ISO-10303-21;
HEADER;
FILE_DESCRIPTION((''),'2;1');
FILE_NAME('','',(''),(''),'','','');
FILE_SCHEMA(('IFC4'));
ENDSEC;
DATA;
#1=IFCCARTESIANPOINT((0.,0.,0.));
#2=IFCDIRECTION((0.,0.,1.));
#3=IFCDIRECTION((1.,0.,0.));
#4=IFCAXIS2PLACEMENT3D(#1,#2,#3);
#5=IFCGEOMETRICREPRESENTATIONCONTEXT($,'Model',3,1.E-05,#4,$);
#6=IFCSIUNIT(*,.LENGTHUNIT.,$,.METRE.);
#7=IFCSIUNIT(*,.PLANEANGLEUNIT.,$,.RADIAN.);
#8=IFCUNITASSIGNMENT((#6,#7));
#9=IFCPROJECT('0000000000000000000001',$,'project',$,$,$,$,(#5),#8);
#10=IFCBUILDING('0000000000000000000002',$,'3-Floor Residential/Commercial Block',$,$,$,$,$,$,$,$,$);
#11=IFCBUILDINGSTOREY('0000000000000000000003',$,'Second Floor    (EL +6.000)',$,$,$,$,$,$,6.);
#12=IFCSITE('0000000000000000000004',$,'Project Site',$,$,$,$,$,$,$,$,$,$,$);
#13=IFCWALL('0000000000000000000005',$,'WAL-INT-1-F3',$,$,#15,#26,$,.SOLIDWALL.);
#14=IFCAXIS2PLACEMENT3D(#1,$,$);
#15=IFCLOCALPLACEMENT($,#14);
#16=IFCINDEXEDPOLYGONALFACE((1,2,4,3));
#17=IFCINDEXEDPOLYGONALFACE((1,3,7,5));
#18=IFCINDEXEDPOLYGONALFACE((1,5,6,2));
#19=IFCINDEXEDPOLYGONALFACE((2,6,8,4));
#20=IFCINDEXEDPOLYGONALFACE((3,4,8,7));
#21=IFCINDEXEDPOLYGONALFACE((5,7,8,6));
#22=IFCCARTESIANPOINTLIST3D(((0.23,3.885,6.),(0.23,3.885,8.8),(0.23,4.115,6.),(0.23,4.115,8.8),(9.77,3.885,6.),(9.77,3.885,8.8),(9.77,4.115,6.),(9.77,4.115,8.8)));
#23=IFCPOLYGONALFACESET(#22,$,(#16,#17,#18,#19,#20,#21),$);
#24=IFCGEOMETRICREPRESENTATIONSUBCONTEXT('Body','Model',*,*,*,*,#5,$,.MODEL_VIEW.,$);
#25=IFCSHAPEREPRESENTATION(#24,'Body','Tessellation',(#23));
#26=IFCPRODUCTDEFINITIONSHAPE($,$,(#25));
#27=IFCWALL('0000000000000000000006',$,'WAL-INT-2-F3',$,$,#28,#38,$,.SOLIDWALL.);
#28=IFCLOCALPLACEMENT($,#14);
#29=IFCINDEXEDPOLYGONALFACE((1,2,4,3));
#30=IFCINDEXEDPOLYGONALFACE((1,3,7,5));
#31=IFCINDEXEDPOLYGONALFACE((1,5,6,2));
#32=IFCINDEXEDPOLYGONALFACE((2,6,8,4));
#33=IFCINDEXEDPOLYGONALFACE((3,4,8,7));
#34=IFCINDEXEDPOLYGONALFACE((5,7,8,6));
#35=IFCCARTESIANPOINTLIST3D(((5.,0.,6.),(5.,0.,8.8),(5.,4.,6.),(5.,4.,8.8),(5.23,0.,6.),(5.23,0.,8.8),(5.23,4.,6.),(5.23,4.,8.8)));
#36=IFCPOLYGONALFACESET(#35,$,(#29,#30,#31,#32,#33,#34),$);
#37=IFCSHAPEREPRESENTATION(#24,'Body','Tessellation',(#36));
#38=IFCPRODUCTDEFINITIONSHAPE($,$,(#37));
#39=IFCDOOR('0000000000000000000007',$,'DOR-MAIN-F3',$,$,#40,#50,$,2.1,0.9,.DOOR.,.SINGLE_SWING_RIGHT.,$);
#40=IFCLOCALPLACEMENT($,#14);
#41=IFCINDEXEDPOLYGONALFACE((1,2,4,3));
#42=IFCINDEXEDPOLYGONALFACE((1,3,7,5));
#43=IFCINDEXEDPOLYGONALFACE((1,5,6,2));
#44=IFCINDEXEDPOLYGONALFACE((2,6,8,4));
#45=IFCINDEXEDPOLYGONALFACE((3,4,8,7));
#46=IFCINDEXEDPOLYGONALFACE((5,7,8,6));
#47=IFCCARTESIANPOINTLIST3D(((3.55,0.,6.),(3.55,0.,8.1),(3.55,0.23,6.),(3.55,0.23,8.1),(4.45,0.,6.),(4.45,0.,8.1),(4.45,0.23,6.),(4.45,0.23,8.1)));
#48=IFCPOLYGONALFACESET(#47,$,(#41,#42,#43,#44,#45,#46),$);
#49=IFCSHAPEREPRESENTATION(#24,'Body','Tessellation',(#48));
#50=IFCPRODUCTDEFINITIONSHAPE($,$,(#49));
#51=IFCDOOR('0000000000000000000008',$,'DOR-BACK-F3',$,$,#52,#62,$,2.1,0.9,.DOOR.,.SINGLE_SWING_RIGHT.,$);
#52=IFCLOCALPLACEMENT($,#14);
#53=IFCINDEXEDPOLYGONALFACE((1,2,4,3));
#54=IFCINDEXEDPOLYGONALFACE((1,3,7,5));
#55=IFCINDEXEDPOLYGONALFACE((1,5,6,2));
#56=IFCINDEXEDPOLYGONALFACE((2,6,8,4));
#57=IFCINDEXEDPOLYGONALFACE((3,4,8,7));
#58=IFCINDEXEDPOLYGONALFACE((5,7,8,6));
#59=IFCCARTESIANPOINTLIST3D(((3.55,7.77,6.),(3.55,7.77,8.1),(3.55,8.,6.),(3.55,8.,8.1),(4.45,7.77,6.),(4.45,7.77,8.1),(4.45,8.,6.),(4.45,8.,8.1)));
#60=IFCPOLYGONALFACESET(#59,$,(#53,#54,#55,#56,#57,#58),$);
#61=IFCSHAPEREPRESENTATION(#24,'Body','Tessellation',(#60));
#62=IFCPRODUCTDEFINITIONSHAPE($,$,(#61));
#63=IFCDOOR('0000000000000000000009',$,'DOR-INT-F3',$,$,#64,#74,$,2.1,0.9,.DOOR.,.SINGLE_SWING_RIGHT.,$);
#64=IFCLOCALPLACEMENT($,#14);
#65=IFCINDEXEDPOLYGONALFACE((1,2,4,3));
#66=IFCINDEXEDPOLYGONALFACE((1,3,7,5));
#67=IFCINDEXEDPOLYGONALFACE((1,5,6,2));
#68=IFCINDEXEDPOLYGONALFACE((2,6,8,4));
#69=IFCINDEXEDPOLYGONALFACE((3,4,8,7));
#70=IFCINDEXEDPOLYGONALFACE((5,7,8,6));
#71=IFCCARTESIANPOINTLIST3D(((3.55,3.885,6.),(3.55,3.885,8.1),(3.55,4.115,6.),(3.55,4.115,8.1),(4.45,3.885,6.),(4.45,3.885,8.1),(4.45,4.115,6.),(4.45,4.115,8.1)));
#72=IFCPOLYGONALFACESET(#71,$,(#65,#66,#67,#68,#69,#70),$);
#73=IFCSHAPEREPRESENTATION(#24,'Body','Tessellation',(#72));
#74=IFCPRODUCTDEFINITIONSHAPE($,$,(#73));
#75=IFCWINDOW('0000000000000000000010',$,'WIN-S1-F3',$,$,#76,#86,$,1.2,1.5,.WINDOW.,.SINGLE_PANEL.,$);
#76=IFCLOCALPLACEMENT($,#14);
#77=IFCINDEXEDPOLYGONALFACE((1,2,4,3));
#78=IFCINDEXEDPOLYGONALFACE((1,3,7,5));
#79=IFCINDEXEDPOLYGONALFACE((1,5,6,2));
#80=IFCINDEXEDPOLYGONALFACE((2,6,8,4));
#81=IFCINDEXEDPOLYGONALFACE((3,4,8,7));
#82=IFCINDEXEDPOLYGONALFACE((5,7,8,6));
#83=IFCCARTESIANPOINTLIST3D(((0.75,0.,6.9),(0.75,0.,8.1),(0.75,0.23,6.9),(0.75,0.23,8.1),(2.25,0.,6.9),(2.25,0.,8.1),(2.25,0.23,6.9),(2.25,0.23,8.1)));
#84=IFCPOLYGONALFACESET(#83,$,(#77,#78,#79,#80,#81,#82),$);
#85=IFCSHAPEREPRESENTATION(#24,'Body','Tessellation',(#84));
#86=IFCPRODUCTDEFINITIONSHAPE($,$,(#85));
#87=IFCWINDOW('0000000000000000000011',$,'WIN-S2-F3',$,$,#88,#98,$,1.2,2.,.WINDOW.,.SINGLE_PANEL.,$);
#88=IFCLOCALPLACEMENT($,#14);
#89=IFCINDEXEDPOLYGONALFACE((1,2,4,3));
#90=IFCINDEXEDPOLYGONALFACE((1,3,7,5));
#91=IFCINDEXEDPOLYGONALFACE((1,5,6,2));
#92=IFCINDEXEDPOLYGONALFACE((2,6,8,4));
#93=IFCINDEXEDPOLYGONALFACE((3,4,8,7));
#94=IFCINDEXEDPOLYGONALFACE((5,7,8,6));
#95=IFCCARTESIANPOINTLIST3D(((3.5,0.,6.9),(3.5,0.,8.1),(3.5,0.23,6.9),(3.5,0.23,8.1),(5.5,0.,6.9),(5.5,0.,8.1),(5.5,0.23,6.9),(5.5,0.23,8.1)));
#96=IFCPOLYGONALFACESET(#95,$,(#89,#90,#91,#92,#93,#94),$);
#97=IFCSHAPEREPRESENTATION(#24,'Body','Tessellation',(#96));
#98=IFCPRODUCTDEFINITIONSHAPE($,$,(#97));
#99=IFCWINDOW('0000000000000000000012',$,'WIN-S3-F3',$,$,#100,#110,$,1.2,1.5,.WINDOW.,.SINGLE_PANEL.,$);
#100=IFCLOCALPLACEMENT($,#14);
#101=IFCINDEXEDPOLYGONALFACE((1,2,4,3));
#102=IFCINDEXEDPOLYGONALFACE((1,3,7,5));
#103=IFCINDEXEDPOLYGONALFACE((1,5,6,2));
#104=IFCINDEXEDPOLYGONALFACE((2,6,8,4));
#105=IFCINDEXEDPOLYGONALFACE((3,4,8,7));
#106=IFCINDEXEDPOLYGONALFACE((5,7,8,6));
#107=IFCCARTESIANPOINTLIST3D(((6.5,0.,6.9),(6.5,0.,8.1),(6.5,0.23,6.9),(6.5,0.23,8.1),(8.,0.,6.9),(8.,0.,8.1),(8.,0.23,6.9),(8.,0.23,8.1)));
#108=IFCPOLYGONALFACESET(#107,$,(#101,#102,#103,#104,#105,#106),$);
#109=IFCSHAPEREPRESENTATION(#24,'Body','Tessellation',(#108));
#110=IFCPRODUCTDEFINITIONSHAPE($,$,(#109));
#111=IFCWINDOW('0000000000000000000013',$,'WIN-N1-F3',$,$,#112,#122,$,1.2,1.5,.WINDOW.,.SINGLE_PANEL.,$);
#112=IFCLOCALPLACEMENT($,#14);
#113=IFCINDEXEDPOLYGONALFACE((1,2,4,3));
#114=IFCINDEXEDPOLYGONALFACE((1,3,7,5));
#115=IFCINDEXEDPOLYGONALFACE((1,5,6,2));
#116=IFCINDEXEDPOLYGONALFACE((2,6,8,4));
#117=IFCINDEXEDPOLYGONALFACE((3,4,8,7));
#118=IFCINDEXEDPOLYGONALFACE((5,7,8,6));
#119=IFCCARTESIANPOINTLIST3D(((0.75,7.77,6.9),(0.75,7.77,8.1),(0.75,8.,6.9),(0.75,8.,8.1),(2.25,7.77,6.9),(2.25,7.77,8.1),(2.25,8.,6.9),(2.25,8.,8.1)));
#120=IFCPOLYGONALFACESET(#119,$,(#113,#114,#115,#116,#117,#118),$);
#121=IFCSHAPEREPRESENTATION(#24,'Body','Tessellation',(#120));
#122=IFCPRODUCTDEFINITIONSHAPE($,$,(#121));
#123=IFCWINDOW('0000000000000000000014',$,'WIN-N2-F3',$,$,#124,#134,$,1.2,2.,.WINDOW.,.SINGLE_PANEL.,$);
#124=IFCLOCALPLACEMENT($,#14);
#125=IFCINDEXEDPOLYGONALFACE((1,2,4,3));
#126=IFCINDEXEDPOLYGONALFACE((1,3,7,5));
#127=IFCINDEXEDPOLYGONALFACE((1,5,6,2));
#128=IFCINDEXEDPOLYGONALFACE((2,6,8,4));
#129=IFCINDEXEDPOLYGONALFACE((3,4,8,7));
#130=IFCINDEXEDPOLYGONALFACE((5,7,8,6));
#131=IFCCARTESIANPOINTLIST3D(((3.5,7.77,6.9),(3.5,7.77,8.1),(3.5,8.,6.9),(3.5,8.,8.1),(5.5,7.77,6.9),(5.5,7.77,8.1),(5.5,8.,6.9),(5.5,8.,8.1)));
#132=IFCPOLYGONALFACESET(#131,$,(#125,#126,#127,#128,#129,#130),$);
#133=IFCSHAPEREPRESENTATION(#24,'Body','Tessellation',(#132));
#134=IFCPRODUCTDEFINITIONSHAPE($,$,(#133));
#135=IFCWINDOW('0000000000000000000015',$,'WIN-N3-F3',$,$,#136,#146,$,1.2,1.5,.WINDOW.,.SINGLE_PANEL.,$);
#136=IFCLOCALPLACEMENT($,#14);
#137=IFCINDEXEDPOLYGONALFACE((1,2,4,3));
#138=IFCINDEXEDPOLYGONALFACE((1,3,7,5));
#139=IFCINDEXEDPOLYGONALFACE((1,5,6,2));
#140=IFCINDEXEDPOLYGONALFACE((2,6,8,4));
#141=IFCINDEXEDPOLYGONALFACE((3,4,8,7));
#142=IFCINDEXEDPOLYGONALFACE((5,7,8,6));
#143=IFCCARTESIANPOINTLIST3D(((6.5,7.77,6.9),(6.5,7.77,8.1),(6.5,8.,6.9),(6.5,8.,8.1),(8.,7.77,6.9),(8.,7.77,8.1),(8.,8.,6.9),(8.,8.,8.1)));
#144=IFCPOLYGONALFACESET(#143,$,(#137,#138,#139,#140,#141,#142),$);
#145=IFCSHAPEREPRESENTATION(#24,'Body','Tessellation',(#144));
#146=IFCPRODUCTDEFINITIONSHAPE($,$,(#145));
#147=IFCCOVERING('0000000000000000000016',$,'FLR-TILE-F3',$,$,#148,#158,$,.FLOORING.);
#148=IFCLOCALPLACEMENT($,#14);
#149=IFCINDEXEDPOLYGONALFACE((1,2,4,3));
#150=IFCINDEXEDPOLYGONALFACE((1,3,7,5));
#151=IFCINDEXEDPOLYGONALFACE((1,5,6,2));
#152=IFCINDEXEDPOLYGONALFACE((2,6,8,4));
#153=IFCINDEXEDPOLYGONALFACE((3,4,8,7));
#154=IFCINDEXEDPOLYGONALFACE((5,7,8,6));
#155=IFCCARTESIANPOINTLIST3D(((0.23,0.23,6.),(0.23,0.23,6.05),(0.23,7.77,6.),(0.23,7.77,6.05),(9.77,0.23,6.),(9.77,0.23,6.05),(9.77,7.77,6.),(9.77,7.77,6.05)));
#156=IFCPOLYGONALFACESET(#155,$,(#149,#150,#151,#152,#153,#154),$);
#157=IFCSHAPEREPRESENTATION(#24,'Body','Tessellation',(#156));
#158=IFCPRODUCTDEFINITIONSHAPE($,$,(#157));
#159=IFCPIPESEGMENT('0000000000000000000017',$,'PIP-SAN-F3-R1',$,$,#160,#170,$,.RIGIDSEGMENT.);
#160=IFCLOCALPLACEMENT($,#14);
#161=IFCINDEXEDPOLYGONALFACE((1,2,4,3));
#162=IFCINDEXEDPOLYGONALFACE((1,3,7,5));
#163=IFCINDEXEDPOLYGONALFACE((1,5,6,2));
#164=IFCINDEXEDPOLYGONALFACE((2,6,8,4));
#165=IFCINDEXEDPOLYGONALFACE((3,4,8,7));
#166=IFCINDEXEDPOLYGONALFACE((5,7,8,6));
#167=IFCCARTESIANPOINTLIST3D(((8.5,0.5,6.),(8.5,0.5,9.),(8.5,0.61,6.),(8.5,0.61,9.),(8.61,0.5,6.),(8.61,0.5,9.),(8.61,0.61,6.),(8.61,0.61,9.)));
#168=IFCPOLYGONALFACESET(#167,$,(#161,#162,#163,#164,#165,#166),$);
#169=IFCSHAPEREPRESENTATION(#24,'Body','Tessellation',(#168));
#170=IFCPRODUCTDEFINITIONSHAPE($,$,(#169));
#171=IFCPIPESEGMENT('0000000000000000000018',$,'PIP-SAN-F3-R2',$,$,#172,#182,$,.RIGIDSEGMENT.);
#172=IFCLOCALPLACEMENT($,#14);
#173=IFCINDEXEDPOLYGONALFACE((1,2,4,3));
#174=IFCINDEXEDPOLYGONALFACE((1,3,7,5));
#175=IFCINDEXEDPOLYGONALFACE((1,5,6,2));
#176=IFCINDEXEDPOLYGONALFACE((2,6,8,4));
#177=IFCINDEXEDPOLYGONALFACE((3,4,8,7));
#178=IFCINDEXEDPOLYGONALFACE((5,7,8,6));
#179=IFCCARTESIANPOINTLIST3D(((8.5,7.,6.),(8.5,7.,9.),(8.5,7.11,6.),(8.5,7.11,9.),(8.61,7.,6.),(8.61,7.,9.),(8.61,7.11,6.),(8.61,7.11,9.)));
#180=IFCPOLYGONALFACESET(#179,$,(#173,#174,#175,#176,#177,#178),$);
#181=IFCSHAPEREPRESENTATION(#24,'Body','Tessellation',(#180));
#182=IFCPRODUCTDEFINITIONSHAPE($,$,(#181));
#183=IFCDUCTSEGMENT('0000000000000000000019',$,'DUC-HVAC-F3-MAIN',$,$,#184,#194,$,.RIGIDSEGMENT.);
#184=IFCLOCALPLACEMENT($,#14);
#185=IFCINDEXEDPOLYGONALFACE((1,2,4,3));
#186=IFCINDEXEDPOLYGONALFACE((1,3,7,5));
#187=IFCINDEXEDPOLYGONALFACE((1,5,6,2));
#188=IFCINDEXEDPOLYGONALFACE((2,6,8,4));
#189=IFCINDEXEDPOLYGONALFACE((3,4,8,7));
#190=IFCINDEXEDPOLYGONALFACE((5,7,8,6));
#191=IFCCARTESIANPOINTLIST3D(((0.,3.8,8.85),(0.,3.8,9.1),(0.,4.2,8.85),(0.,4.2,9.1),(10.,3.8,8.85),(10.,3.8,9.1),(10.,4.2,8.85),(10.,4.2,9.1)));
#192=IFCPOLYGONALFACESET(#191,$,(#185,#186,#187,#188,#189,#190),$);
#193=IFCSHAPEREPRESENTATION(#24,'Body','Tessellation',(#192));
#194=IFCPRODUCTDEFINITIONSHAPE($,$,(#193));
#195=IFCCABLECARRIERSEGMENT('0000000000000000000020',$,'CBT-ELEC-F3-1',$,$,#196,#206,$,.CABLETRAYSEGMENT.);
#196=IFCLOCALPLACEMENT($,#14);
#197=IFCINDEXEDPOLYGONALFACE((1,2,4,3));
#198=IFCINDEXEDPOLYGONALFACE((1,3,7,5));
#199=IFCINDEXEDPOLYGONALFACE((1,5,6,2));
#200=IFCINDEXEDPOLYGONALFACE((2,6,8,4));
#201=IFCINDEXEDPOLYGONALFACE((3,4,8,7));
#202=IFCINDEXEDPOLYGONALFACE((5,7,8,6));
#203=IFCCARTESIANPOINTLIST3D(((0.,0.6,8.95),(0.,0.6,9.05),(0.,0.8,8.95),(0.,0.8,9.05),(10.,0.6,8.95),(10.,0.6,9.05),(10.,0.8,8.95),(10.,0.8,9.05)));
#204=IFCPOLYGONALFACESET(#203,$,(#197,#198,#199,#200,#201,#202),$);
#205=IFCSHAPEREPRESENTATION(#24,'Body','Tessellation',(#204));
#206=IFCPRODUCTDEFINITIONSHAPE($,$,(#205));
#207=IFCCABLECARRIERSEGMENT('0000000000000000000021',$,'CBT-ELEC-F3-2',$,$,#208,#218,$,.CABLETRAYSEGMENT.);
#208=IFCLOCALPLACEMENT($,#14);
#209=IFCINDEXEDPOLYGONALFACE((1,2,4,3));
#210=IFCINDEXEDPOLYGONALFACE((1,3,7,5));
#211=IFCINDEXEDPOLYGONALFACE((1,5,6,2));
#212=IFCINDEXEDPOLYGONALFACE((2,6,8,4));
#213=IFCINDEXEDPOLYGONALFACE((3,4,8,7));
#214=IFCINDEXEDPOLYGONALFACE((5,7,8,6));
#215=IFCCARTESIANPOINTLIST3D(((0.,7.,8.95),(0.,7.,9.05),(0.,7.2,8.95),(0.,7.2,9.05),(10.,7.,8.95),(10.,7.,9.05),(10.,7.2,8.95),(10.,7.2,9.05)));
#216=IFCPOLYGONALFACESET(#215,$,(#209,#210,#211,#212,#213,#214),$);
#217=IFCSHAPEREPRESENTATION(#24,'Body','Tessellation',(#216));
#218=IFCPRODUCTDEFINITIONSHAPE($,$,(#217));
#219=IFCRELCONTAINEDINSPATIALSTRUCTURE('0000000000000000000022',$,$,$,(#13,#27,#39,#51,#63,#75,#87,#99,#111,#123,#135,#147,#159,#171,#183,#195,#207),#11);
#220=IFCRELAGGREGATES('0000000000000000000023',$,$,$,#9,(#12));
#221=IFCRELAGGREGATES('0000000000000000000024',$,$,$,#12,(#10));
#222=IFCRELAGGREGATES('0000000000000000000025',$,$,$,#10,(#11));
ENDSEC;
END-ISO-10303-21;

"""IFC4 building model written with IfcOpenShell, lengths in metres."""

from ifc_helpers import new_model, si_unit, frame, frame_2d, origin_with_axes, place, context, subcontext, project, spatial, rectangle, extrude, element, save


model = new_model("IFC4")

# Units and contexts
model_context = context("Model", 3, precision=1e-05, world=origin_with_axes())
body_context = subcontext(model_context, "Body", "Model", "MODEL_VIEW")
ifc_project = project(units=[si_unit("LENGTHUNIT", "METRE"), si_unit("PLANEANGLEUNIT", "RADIAN")], contexts=[model_context])

# Site, building, storey
site = spatial("IfcSite", under=ifc_project, Name="Project Site")
building = spatial("IfcBuilding", under=site, Name="3-Floor Residential/Commercial Block")
storey = spatial("IfcBuildingStorey", under=building, Name="Second Floor    (EL +6.000)", Elevation=6.0)

# Walls
wall_1_placement = place(None, frame((0.23, 3.885, 6.0), z_axis=(0.0, 0.0, 1.0), x_axis=(1.0, 0.0, 0.0)))
element("IfcWall", 1, at=wall_1_placement, inside=storey, Name="WAL-INT-1-F3", PredefinedType="SOLIDWALL", context=body_context, shape_type="SweptSolid", body=[
    extrude(rectangle(XDim=9.54, YDim=0.23, at=frame_2d((4.77, 0.115))), origin_with_axes(), (0.0, 0.0, 1.0), 2.8),
])
wall_2_placement = place(None, frame((5.0, 0.0, 6.0), z_axis=(0.0, 0.0, 1.0), x_axis=(1.0, 0.0, 0.0)))
element("IfcWall", 2, at=wall_2_placement, inside=storey, Name="WAL-INT-2-F3", PredefinedType="SOLIDWALL", context=body_context, shape_type="SweptSolid", body=[
    extrude(rectangle(XDim=0.23, YDim=4.0, at=frame_2d((0.115, 2.0))), origin_with_axes(), (0.0, 0.0, 1.0), 2.8),
])

# Doors
for number, where, z_axis, x_axis, name in (
    (3, (3.55, 0.0, 6.0), (0.0, 0.0, 1.0), (1.0, 0.0, 0.0), "DOR-MAIN-F3"),
    (4, (3.55, 7.77, 6.0), (0.0, 0.0, 1.0), (1.0, 0.0, 0.0), "DOR-BACK-F3"),
    (5, (3.55, 3.885, 6.0), (0.0, 0.0, 1.0), (1.0, 0.0, 0.0), "DOR-INT-F3"),
):
    element("IfcDoor", number, at=place(None, frame(where, z_axis=z_axis, x_axis=x_axis)), inside=storey, Name=name, OperationType="SINGLE_SWING_RIGHT", OverallHeight=2.1, OverallWidth=0.9, PredefinedType="DOOR", context=body_context, shape_type="SweptSolid", body=[
        extrude(rectangle(XDim=0.9, YDim=0.23, at=frame_2d((0.45, 0.115))), origin_with_axes(), (0.0, 0.0, 1.0), 2.1),
    ])

# Windows
window_1_placement = place(None, frame((0.75, 0.0, 6.9), z_axis=(0.0, 0.0, 1.0), x_axis=(1.0, 0.0, 0.0)))
element("IfcWindow", 6, at=window_1_placement, inside=storey, Name="WIN-S1-F3", OverallHeight=1.2, OverallWidth=1.5, PartitioningType="SINGLE_PANEL", PredefinedType="WINDOW", context=body_context, shape_type="SweptSolid", body=[
    extrude(rectangle(XDim=1.5, YDim=0.23, at=frame_2d((0.75, 0.115))), origin_with_axes(), (0.0, 0.0, 1.0), 1.2),
])
window_2_placement = place(None, frame((3.5, 0.0, 6.9), z_axis=(0.0, 0.0, 1.0), x_axis=(1.0, 0.0, 0.0)))
element("IfcWindow", 7, at=window_2_placement, inside=storey, Name="WIN-S2-F3", OverallHeight=1.2, OverallWidth=2.0, PartitioningType="SINGLE_PANEL", PredefinedType="WINDOW", context=body_context, shape_type="SweptSolid", body=[
    extrude(rectangle(XDim=2.0, YDim=0.23, at=frame_2d((1.0, 0.115))), origin_with_axes(), (0.0, 0.0, 1.0), 1.2),
])
for number, where, z_axis, x_axis, name in (
    (8, (6.5, 0.0, 6.9), (0.0, 0.0, 1.0), (1.0, 0.0, 0.0), "WIN-S3-F3"),
    (9, (0.75, 7.77, 6.9), (0.0, 0.0, 1.0), (1.0, 0.0, 0.0), "WIN-N1-F3"),
):
    element("IfcWindow", number, at=place(None, frame(where, z_axis=z_axis, x_axis=x_axis)), inside=storey, Name=name, OverallHeight=1.2, OverallWidth=1.5, PartitioningType="SINGLE_PANEL", PredefinedType="WINDOW", context=body_context, shape_type="SweptSolid", body=[
        extrude(rectangle(XDim=1.5, YDim=0.23, at=frame_2d((0.75, 0.115))), origin_with_axes(), (0.0, 0.0, 1.0), 1.2),
    ])
window_3_placement = place(None, frame((3.5, 7.77, 6.9), z_axis=(0.0, 0.0, 1.0), x_axis=(1.0, 0.0, 0.0)))
element("IfcWindow", 10, at=window_3_placement, inside=storey, Name="WIN-N2-F3", OverallHeight=1.2, OverallWidth=2.0, PartitioningType="SINGLE_PANEL", PredefinedType="WINDOW", context=body_context, shape_type="SweptSolid", body=[
    extrude(rectangle(XDim=2.0, YDim=0.23, at=frame_2d((1.0, 0.115))), origin_with_axes(), (0.0, 0.0, 1.0), 1.2),
])
window_4_placement = place(None, frame((6.5, 7.77, 6.9), z_axis=(0.0, 0.0, 1.0), x_axis=(1.0, 0.0, 0.0)))
element("IfcWindow", 11, at=window_4_placement, inside=storey, Name="WIN-N3-F3", OverallHeight=1.2, OverallWidth=1.5, PartitioningType="SINGLE_PANEL", PredefinedType="WINDOW", context=body_context, shape_type="SweptSolid", body=[
    extrude(rectangle(XDim=1.5, YDim=0.23, at=frame_2d((0.75, 0.115))), origin_with_axes(), (0.0, 0.0, 1.0), 1.2),
])

# Covering
covering_placement = place(None, frame((0.23, 0.23, 6.0), z_axis=(0.0, 0.0, 1.0), x_axis=(1.0, 0.0, 0.0)))
element("IfcCovering", 12, at=covering_placement, inside=storey, Name="FLR-TILE-F3", PredefinedType="FLOORING", context=body_context, shape_type="SweptSolid", body=[
    extrude(rectangle(XDim=9.54, YDim=7.54, at=frame_2d((4.77, 3.77))), origin_with_axes(), (0.0, 0.0, 1.0), 0.05),
])

# Pipe segments
for number, where, z_axis, x_axis, name in (
    (13, (8.5, 0.5, 6.0), (0.0, 0.0, 1.0), (1.0, 0.0, 0.0), "PIP-SAN-F3-R1"),
    (14, (8.5, 7.0, 6.0), (0.0, 0.0, 1.0), (1.0, 0.0, 0.0), "PIP-SAN-F3-R2"),
):
    element("IfcPipeSegment", number, at=place(None, frame(where, z_axis=z_axis, x_axis=x_axis)), inside=storey, Name=name, PredefinedType="RIGIDSEGMENT", context=body_context, shape_type="SweptSolid", body=[
        extrude(rectangle(XDim=0.11, YDim=0.11, at=frame_2d((0.055, 0.055))), origin_with_axes(), (0.0, 0.0, 1.0), 3.0),
    ])

# Duct segment
duct_segment_placement = place(None, frame((0.0, 3.8, 8.85), z_axis=(0.0, 0.0, 1.0), x_axis=(1.0, 0.0, 0.0)))
element("IfcDuctSegment", 15, at=duct_segment_placement, inside=storey, Name="DUC-HVAC-F3-MAIN", PredefinedType="RIGIDSEGMENT", context=body_context, shape_type="SweptSolid", body=[
    extrude(rectangle(XDim=10.0, YDim=0.4, at=frame_2d((5.0, 0.2))), origin_with_axes(), (0.0, 0.0, 1.0), 0.25),
])

# Cable carrier segments
for number, where, z_axis, x_axis, name in (
    (16, (0.0, 0.6, 8.95), (0.0, 0.0, 1.0), (1.0, 0.0, 0.0), "CBT-ELEC-F3-1"),
    (17, (0.0, 7.0, 8.95), (0.0, 0.0, 1.0), (1.0, 0.0, 0.0), "CBT-ELEC-F3-2"),
):
    element("IfcCableCarrierSegment", number, at=place(None, frame(where, z_axis=z_axis, x_axis=x_axis)), inside=storey, Name=name, PredefinedType="CABLETRAYSEGMENT", context=body_context, shape_type="SweptSolid", body=[
        extrude(rectangle(XDim=10.0, YDim=0.2, at=frame_2d((5.0, 0.1))), origin_with_axes(), (0.0, 0.0, 1.0), 0.1),
    ])

save(model, "model.ifc")
